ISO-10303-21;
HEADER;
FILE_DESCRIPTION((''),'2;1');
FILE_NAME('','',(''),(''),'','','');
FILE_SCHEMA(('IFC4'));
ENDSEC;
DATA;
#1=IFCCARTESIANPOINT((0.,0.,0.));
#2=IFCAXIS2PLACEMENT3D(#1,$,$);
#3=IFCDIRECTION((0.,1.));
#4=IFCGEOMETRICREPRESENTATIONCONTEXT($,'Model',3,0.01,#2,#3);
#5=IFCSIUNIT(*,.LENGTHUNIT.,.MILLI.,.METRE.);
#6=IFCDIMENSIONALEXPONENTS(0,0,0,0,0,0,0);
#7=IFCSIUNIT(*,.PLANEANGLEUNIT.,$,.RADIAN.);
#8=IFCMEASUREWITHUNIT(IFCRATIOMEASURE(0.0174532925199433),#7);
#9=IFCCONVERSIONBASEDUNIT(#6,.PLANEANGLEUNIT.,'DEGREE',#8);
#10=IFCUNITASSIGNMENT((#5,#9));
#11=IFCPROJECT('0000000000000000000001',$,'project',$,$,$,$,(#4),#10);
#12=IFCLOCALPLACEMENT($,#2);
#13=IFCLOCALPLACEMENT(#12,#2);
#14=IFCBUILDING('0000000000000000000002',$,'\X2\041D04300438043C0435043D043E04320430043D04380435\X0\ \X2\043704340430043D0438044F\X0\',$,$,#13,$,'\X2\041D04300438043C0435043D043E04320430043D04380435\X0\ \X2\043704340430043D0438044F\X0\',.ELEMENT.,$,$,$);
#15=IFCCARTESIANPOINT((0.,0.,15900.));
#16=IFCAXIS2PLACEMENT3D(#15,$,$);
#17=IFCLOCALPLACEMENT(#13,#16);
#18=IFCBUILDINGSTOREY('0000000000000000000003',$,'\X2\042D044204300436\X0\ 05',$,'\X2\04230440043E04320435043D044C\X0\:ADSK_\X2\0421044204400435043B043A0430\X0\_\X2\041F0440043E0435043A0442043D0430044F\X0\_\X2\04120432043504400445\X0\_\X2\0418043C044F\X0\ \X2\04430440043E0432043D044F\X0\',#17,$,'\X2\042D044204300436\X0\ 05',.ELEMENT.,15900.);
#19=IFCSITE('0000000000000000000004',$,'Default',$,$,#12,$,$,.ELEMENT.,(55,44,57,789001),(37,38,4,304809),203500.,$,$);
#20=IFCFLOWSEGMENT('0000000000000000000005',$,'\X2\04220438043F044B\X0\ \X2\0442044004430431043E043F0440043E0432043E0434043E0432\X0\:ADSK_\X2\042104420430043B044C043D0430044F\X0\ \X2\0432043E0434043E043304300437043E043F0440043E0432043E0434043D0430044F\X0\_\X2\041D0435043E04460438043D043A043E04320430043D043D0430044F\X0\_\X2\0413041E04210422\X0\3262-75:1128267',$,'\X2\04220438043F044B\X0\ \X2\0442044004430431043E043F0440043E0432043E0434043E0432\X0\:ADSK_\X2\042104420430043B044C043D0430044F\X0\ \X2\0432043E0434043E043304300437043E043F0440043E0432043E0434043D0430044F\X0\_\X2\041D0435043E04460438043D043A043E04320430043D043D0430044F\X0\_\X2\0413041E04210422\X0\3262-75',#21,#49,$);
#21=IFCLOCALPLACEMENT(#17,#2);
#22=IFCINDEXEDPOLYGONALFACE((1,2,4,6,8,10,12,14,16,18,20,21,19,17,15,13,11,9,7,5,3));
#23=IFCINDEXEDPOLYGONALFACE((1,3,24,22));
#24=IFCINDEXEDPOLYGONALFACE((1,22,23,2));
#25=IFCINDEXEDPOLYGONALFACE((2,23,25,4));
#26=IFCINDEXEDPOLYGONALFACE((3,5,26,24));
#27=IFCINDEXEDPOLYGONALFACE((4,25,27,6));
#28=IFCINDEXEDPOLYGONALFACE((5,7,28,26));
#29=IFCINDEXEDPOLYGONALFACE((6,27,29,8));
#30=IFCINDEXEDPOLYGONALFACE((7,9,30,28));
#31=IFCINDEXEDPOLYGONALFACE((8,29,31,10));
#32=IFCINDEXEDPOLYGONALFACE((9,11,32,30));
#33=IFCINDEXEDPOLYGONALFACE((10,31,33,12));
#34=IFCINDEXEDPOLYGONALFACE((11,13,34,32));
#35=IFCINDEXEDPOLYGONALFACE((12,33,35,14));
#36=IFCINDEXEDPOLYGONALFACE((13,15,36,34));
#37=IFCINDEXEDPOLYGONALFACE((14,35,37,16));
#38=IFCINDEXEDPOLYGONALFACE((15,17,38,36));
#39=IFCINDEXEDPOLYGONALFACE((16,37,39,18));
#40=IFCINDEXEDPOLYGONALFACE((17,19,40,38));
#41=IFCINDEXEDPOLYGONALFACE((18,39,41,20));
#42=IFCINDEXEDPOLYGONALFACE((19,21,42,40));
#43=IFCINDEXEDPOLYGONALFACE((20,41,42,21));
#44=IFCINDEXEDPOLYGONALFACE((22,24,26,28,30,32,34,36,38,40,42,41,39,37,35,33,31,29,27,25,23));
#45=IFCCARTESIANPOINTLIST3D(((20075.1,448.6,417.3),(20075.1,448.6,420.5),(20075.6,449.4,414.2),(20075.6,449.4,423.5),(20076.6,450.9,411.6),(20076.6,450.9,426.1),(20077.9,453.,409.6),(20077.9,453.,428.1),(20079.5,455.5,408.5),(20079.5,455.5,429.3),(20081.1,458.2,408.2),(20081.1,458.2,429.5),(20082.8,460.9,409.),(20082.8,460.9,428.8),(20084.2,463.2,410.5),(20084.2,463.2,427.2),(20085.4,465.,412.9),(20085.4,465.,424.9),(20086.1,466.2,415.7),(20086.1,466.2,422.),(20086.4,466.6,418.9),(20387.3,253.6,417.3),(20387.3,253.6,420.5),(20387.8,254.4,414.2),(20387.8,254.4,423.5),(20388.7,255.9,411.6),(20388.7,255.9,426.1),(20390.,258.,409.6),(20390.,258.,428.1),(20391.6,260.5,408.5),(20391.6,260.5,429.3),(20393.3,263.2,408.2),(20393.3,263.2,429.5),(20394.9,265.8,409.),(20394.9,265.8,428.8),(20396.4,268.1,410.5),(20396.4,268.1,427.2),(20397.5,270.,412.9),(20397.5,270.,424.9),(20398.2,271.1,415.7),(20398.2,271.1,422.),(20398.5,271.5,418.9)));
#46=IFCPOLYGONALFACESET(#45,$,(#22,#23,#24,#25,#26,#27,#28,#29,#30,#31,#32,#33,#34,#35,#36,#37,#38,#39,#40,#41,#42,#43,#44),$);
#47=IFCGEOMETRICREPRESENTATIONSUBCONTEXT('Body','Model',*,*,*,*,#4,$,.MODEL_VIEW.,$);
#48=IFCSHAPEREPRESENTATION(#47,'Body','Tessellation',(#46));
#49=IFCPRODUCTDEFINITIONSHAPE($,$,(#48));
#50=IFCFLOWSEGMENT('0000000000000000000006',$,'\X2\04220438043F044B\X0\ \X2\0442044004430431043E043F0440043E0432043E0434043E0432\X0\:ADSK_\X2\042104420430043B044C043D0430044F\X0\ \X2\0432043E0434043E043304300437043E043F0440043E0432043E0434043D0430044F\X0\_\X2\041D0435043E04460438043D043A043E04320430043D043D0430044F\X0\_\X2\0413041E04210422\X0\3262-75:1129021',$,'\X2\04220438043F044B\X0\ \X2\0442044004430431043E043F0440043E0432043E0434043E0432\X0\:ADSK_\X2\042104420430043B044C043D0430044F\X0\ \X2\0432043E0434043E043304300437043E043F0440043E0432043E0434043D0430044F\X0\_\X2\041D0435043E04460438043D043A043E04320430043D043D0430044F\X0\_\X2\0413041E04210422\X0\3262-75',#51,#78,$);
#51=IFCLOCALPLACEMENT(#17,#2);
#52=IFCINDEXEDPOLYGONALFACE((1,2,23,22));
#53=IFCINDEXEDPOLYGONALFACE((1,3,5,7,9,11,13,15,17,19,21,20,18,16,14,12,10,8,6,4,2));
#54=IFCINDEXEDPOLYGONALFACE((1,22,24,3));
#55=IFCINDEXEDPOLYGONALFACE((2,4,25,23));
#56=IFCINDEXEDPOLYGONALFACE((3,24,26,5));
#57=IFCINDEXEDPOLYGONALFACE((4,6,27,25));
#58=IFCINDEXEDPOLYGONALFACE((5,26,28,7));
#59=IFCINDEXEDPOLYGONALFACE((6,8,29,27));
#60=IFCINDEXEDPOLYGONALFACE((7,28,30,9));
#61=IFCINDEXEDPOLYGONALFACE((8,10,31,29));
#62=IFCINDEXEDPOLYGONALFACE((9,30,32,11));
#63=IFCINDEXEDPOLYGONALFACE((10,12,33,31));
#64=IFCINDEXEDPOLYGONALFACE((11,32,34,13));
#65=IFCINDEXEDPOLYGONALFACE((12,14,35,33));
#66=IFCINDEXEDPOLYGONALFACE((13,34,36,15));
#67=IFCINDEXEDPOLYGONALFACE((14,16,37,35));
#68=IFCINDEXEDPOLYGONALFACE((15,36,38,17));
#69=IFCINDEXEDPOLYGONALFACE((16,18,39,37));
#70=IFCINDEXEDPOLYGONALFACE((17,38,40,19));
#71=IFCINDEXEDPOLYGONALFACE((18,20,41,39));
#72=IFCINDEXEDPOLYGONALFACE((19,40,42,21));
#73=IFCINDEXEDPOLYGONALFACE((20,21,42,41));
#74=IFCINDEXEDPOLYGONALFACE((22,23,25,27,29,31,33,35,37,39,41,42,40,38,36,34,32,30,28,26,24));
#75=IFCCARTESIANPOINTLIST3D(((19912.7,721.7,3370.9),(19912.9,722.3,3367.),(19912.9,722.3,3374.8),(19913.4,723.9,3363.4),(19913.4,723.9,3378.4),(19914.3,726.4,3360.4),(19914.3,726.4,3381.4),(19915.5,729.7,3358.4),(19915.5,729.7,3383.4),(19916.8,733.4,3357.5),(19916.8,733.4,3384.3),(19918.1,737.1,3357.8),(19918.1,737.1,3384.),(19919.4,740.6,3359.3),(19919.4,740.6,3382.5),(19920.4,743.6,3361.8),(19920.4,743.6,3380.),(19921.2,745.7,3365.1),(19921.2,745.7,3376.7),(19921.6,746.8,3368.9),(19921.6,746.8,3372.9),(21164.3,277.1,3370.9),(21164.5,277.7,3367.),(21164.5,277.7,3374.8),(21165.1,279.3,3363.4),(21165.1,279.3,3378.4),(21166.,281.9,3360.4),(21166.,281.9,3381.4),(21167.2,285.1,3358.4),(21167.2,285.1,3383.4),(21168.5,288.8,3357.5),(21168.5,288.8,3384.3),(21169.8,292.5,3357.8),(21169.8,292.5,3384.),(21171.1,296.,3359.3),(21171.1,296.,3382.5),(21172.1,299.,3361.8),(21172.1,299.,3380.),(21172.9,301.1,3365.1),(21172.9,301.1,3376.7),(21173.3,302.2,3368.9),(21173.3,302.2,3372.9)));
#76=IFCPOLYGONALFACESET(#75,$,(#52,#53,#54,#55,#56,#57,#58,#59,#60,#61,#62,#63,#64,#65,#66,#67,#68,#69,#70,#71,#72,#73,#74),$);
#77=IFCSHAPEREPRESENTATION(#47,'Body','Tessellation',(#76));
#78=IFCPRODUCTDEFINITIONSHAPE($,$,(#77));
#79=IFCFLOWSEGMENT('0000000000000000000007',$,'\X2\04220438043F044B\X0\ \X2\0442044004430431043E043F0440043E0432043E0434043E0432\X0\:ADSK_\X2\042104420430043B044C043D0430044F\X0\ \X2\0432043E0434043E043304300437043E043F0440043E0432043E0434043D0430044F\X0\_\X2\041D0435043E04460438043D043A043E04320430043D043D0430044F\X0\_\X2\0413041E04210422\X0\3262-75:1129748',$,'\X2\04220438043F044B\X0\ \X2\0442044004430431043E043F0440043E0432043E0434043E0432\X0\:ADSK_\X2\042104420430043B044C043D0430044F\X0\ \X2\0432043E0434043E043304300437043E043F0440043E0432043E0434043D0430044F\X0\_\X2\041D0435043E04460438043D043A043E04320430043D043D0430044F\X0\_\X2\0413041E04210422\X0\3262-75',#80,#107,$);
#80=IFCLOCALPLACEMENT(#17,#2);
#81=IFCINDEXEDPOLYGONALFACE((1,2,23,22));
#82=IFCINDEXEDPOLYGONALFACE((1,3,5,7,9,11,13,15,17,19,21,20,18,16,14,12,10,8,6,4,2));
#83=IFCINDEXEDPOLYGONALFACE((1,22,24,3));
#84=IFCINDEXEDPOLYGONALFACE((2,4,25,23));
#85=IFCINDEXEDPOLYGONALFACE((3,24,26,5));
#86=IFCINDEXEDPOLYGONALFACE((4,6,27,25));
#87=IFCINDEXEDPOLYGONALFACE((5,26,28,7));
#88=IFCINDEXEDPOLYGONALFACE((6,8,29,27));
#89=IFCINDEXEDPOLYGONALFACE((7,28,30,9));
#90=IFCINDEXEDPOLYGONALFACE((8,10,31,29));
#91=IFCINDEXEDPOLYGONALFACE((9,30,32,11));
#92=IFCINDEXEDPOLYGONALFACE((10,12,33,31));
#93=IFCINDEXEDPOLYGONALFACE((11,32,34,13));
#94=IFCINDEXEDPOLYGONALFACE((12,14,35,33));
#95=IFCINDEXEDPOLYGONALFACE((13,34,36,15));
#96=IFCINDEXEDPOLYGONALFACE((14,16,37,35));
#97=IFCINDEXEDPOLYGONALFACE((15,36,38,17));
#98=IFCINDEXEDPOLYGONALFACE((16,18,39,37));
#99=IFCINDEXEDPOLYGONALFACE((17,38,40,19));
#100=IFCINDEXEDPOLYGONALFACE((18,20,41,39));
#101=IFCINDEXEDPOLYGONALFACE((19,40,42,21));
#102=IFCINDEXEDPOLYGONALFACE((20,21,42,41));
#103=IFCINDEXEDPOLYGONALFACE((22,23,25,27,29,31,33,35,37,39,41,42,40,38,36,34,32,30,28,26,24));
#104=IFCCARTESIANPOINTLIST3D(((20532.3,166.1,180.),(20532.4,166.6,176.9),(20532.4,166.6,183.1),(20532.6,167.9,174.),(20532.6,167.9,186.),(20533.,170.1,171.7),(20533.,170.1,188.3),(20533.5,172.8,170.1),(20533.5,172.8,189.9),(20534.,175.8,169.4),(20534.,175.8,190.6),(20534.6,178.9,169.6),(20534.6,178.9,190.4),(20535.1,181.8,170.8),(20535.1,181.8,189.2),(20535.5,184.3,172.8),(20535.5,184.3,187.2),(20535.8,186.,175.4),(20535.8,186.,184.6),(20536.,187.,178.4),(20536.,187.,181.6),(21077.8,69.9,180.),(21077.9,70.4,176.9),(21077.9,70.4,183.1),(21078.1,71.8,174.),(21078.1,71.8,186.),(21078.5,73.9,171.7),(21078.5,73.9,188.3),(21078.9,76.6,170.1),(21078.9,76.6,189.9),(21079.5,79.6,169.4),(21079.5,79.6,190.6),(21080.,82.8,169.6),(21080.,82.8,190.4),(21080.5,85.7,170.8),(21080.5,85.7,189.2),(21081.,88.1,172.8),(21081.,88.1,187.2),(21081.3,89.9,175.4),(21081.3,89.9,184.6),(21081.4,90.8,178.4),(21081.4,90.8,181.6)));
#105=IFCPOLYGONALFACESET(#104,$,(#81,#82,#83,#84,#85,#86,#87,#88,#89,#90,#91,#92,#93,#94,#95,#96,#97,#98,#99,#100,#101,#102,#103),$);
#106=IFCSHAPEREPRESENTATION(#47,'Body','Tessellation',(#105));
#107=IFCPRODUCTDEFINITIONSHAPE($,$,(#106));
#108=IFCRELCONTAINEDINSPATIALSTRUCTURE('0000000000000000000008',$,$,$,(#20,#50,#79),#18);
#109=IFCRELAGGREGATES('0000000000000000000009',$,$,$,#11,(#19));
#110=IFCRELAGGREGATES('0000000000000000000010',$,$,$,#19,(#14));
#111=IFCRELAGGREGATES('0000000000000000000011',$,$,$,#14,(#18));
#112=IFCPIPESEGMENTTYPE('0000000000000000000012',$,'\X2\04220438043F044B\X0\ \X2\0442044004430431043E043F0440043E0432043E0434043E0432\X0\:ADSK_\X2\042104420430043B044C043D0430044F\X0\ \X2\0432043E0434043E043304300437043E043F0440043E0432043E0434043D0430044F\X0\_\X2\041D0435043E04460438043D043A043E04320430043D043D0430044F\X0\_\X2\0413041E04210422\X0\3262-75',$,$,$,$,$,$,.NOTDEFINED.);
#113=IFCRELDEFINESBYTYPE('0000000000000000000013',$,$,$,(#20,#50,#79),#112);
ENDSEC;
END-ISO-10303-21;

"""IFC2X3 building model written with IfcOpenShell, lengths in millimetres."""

from ifc_helpers import new_model, entity, si_unit, converted_unit, direction, frame, origin, origin_2d_with_axis, place, context, subcontext, project, spatial, circle, extrude, type_object, element, save


model = new_model("IFC2X3")

# Units and contexts
model_context = context("Model", 3, precision=0.01, world=origin(), true_north=direction((0.0, 1.0)))
body_context = subcontext(model_context, "Body", "Model", "MODEL_VIEW")
ifc_project = project(units=[si_unit("LENGTHUNIT", "METRE", prefix="MILLI"), converted_unit("PLANEANGLEUNIT", "DEGREE", entity("IfcRatioMeasure", 0.0174532925199433), si_unit("PLANEANGLEUNIT", "RADIAN"), dimensions=[0, 0, 0, 0, 0, 0, 0])], contexts=[model_context])

# Site, building, storey
site_placement = place(None, origin())
site = spatial("IfcSite", under=ifc_project, at=site_placement, Name="Default", CompositionType="ELEMENT", RefLatitude=(55, 44, 57, 789001), RefLongitude=(37, 38, 4, 304809), RefElevation=203500.0)
building_placement = place(site_placement, origin())
building = spatial("IfcBuilding", under=site, at=building_placement, Name="Наименование здания", LongName="Наименование здания", CompositionType="ELEMENT")
storey_placement = place(building_placement, frame((0.0, 0.0, 15900.0)))
storey = spatial("IfcBuildingStorey", under=building, at=storey_placement, Name="Этаж 05", ObjectType="Уровень:ADSK_Стрелка_Проектная_Вверх_Имя уровня", LongName="Этаж 05", CompositionType="ELEMENT", Elevation=15900.0)

# Flow segments
pipe_segment_type = type_object("IfcPipeSegmentType", Name="Типы трубопроводов:ADSK_Стальная водогазопроводная_Неоцинкованная_ГОСТ3262-75", PredefinedType="NOTDEFINED")
flow_segment_1_placement = place(storey_placement, frame((20073.5, 251.9, 406.6)))
element("IfcFlowSegment", 1, at=flow_segment_1_placement, inside=storey, type_object=pipe_segment_type, Name="Типы трубопроводов:ADSK_Стальная водогазопроводная_Неоцинкованная_ГОСТ3262-75:1128267", ObjectType="Типы трубопроводов:ADSK_Стальная водогазопроводная_Неоцинкованная_ГОСТ3262-75", context=body_context, shape_type="SweptSolid", body=[
    extrude(circle(Radius=10.7, at=origin_2d_with_axis()), frame((319.4, 10.6, 12.2), z_axis=(-0.848048, 0.529919, 0.0), x_axis=(0.529919, 0.848048, 0.0)), (0.0, 0.0, 1.0), 368.1),
])
flow_segment_2_placement = place(storey_placement, frame((19911.1, 275.5, 3355.9)))
element("IfcFlowSegment", 2, at=flow_segment_2_placement, inside=storey, type_object=pipe_segment_type, Name="Типы трубопроводов:ADSK_Стальная водогазопроводная_Неоцинкованная_ГОСТ3262-75:1129021", ObjectType="Типы трубопроводов:ADSK_Стальная водогазопроводная_Неоцинкованная_ГОСТ3262-75", context=body_context, shape_type="SweptSolid", body=[
    extrude(circle(Radius=13.4, at=origin_2d_with_axis()), frame((1257.8, 14.2, 15.0), z_axis=(-0.942322, 0.334708, 0.0), x_axis=(-0.334708, -0.942322, 0.0)), (0.0, 0.0, 1.0), 1328.3),
])
flow_segment_3_placement = place(storey_placement, frame((20530.7, 68.3, 167.8)))
element("IfcFlowSegment", 3, at=flow_segment_3_placement, inside=storey, type_object=pipe_segment_type, Name="Типы трубопроводов:ADSK_Стальная водогазопроводная_Неоцинкованная_ГОСТ3262-75:1129748", ObjectType="Типы трубопроводов:ADSK_Стальная водогазопроводная_Неоцинкованная_ГОСТ3262-75", context=body_context, shape_type="SweptSolid", body=[
    extrude(circle(Radius=10.7, at=origin_2d_with_axis()), frame((548.9, 12.1, 12.2), z_axis=(-0.984808, 0.173648, 0.0), x_axis=(-0.173648, -0.984808, 0.0)), (0.0, 0.0, 1.0), 553.9),
])

save(model, "model.ifc")
